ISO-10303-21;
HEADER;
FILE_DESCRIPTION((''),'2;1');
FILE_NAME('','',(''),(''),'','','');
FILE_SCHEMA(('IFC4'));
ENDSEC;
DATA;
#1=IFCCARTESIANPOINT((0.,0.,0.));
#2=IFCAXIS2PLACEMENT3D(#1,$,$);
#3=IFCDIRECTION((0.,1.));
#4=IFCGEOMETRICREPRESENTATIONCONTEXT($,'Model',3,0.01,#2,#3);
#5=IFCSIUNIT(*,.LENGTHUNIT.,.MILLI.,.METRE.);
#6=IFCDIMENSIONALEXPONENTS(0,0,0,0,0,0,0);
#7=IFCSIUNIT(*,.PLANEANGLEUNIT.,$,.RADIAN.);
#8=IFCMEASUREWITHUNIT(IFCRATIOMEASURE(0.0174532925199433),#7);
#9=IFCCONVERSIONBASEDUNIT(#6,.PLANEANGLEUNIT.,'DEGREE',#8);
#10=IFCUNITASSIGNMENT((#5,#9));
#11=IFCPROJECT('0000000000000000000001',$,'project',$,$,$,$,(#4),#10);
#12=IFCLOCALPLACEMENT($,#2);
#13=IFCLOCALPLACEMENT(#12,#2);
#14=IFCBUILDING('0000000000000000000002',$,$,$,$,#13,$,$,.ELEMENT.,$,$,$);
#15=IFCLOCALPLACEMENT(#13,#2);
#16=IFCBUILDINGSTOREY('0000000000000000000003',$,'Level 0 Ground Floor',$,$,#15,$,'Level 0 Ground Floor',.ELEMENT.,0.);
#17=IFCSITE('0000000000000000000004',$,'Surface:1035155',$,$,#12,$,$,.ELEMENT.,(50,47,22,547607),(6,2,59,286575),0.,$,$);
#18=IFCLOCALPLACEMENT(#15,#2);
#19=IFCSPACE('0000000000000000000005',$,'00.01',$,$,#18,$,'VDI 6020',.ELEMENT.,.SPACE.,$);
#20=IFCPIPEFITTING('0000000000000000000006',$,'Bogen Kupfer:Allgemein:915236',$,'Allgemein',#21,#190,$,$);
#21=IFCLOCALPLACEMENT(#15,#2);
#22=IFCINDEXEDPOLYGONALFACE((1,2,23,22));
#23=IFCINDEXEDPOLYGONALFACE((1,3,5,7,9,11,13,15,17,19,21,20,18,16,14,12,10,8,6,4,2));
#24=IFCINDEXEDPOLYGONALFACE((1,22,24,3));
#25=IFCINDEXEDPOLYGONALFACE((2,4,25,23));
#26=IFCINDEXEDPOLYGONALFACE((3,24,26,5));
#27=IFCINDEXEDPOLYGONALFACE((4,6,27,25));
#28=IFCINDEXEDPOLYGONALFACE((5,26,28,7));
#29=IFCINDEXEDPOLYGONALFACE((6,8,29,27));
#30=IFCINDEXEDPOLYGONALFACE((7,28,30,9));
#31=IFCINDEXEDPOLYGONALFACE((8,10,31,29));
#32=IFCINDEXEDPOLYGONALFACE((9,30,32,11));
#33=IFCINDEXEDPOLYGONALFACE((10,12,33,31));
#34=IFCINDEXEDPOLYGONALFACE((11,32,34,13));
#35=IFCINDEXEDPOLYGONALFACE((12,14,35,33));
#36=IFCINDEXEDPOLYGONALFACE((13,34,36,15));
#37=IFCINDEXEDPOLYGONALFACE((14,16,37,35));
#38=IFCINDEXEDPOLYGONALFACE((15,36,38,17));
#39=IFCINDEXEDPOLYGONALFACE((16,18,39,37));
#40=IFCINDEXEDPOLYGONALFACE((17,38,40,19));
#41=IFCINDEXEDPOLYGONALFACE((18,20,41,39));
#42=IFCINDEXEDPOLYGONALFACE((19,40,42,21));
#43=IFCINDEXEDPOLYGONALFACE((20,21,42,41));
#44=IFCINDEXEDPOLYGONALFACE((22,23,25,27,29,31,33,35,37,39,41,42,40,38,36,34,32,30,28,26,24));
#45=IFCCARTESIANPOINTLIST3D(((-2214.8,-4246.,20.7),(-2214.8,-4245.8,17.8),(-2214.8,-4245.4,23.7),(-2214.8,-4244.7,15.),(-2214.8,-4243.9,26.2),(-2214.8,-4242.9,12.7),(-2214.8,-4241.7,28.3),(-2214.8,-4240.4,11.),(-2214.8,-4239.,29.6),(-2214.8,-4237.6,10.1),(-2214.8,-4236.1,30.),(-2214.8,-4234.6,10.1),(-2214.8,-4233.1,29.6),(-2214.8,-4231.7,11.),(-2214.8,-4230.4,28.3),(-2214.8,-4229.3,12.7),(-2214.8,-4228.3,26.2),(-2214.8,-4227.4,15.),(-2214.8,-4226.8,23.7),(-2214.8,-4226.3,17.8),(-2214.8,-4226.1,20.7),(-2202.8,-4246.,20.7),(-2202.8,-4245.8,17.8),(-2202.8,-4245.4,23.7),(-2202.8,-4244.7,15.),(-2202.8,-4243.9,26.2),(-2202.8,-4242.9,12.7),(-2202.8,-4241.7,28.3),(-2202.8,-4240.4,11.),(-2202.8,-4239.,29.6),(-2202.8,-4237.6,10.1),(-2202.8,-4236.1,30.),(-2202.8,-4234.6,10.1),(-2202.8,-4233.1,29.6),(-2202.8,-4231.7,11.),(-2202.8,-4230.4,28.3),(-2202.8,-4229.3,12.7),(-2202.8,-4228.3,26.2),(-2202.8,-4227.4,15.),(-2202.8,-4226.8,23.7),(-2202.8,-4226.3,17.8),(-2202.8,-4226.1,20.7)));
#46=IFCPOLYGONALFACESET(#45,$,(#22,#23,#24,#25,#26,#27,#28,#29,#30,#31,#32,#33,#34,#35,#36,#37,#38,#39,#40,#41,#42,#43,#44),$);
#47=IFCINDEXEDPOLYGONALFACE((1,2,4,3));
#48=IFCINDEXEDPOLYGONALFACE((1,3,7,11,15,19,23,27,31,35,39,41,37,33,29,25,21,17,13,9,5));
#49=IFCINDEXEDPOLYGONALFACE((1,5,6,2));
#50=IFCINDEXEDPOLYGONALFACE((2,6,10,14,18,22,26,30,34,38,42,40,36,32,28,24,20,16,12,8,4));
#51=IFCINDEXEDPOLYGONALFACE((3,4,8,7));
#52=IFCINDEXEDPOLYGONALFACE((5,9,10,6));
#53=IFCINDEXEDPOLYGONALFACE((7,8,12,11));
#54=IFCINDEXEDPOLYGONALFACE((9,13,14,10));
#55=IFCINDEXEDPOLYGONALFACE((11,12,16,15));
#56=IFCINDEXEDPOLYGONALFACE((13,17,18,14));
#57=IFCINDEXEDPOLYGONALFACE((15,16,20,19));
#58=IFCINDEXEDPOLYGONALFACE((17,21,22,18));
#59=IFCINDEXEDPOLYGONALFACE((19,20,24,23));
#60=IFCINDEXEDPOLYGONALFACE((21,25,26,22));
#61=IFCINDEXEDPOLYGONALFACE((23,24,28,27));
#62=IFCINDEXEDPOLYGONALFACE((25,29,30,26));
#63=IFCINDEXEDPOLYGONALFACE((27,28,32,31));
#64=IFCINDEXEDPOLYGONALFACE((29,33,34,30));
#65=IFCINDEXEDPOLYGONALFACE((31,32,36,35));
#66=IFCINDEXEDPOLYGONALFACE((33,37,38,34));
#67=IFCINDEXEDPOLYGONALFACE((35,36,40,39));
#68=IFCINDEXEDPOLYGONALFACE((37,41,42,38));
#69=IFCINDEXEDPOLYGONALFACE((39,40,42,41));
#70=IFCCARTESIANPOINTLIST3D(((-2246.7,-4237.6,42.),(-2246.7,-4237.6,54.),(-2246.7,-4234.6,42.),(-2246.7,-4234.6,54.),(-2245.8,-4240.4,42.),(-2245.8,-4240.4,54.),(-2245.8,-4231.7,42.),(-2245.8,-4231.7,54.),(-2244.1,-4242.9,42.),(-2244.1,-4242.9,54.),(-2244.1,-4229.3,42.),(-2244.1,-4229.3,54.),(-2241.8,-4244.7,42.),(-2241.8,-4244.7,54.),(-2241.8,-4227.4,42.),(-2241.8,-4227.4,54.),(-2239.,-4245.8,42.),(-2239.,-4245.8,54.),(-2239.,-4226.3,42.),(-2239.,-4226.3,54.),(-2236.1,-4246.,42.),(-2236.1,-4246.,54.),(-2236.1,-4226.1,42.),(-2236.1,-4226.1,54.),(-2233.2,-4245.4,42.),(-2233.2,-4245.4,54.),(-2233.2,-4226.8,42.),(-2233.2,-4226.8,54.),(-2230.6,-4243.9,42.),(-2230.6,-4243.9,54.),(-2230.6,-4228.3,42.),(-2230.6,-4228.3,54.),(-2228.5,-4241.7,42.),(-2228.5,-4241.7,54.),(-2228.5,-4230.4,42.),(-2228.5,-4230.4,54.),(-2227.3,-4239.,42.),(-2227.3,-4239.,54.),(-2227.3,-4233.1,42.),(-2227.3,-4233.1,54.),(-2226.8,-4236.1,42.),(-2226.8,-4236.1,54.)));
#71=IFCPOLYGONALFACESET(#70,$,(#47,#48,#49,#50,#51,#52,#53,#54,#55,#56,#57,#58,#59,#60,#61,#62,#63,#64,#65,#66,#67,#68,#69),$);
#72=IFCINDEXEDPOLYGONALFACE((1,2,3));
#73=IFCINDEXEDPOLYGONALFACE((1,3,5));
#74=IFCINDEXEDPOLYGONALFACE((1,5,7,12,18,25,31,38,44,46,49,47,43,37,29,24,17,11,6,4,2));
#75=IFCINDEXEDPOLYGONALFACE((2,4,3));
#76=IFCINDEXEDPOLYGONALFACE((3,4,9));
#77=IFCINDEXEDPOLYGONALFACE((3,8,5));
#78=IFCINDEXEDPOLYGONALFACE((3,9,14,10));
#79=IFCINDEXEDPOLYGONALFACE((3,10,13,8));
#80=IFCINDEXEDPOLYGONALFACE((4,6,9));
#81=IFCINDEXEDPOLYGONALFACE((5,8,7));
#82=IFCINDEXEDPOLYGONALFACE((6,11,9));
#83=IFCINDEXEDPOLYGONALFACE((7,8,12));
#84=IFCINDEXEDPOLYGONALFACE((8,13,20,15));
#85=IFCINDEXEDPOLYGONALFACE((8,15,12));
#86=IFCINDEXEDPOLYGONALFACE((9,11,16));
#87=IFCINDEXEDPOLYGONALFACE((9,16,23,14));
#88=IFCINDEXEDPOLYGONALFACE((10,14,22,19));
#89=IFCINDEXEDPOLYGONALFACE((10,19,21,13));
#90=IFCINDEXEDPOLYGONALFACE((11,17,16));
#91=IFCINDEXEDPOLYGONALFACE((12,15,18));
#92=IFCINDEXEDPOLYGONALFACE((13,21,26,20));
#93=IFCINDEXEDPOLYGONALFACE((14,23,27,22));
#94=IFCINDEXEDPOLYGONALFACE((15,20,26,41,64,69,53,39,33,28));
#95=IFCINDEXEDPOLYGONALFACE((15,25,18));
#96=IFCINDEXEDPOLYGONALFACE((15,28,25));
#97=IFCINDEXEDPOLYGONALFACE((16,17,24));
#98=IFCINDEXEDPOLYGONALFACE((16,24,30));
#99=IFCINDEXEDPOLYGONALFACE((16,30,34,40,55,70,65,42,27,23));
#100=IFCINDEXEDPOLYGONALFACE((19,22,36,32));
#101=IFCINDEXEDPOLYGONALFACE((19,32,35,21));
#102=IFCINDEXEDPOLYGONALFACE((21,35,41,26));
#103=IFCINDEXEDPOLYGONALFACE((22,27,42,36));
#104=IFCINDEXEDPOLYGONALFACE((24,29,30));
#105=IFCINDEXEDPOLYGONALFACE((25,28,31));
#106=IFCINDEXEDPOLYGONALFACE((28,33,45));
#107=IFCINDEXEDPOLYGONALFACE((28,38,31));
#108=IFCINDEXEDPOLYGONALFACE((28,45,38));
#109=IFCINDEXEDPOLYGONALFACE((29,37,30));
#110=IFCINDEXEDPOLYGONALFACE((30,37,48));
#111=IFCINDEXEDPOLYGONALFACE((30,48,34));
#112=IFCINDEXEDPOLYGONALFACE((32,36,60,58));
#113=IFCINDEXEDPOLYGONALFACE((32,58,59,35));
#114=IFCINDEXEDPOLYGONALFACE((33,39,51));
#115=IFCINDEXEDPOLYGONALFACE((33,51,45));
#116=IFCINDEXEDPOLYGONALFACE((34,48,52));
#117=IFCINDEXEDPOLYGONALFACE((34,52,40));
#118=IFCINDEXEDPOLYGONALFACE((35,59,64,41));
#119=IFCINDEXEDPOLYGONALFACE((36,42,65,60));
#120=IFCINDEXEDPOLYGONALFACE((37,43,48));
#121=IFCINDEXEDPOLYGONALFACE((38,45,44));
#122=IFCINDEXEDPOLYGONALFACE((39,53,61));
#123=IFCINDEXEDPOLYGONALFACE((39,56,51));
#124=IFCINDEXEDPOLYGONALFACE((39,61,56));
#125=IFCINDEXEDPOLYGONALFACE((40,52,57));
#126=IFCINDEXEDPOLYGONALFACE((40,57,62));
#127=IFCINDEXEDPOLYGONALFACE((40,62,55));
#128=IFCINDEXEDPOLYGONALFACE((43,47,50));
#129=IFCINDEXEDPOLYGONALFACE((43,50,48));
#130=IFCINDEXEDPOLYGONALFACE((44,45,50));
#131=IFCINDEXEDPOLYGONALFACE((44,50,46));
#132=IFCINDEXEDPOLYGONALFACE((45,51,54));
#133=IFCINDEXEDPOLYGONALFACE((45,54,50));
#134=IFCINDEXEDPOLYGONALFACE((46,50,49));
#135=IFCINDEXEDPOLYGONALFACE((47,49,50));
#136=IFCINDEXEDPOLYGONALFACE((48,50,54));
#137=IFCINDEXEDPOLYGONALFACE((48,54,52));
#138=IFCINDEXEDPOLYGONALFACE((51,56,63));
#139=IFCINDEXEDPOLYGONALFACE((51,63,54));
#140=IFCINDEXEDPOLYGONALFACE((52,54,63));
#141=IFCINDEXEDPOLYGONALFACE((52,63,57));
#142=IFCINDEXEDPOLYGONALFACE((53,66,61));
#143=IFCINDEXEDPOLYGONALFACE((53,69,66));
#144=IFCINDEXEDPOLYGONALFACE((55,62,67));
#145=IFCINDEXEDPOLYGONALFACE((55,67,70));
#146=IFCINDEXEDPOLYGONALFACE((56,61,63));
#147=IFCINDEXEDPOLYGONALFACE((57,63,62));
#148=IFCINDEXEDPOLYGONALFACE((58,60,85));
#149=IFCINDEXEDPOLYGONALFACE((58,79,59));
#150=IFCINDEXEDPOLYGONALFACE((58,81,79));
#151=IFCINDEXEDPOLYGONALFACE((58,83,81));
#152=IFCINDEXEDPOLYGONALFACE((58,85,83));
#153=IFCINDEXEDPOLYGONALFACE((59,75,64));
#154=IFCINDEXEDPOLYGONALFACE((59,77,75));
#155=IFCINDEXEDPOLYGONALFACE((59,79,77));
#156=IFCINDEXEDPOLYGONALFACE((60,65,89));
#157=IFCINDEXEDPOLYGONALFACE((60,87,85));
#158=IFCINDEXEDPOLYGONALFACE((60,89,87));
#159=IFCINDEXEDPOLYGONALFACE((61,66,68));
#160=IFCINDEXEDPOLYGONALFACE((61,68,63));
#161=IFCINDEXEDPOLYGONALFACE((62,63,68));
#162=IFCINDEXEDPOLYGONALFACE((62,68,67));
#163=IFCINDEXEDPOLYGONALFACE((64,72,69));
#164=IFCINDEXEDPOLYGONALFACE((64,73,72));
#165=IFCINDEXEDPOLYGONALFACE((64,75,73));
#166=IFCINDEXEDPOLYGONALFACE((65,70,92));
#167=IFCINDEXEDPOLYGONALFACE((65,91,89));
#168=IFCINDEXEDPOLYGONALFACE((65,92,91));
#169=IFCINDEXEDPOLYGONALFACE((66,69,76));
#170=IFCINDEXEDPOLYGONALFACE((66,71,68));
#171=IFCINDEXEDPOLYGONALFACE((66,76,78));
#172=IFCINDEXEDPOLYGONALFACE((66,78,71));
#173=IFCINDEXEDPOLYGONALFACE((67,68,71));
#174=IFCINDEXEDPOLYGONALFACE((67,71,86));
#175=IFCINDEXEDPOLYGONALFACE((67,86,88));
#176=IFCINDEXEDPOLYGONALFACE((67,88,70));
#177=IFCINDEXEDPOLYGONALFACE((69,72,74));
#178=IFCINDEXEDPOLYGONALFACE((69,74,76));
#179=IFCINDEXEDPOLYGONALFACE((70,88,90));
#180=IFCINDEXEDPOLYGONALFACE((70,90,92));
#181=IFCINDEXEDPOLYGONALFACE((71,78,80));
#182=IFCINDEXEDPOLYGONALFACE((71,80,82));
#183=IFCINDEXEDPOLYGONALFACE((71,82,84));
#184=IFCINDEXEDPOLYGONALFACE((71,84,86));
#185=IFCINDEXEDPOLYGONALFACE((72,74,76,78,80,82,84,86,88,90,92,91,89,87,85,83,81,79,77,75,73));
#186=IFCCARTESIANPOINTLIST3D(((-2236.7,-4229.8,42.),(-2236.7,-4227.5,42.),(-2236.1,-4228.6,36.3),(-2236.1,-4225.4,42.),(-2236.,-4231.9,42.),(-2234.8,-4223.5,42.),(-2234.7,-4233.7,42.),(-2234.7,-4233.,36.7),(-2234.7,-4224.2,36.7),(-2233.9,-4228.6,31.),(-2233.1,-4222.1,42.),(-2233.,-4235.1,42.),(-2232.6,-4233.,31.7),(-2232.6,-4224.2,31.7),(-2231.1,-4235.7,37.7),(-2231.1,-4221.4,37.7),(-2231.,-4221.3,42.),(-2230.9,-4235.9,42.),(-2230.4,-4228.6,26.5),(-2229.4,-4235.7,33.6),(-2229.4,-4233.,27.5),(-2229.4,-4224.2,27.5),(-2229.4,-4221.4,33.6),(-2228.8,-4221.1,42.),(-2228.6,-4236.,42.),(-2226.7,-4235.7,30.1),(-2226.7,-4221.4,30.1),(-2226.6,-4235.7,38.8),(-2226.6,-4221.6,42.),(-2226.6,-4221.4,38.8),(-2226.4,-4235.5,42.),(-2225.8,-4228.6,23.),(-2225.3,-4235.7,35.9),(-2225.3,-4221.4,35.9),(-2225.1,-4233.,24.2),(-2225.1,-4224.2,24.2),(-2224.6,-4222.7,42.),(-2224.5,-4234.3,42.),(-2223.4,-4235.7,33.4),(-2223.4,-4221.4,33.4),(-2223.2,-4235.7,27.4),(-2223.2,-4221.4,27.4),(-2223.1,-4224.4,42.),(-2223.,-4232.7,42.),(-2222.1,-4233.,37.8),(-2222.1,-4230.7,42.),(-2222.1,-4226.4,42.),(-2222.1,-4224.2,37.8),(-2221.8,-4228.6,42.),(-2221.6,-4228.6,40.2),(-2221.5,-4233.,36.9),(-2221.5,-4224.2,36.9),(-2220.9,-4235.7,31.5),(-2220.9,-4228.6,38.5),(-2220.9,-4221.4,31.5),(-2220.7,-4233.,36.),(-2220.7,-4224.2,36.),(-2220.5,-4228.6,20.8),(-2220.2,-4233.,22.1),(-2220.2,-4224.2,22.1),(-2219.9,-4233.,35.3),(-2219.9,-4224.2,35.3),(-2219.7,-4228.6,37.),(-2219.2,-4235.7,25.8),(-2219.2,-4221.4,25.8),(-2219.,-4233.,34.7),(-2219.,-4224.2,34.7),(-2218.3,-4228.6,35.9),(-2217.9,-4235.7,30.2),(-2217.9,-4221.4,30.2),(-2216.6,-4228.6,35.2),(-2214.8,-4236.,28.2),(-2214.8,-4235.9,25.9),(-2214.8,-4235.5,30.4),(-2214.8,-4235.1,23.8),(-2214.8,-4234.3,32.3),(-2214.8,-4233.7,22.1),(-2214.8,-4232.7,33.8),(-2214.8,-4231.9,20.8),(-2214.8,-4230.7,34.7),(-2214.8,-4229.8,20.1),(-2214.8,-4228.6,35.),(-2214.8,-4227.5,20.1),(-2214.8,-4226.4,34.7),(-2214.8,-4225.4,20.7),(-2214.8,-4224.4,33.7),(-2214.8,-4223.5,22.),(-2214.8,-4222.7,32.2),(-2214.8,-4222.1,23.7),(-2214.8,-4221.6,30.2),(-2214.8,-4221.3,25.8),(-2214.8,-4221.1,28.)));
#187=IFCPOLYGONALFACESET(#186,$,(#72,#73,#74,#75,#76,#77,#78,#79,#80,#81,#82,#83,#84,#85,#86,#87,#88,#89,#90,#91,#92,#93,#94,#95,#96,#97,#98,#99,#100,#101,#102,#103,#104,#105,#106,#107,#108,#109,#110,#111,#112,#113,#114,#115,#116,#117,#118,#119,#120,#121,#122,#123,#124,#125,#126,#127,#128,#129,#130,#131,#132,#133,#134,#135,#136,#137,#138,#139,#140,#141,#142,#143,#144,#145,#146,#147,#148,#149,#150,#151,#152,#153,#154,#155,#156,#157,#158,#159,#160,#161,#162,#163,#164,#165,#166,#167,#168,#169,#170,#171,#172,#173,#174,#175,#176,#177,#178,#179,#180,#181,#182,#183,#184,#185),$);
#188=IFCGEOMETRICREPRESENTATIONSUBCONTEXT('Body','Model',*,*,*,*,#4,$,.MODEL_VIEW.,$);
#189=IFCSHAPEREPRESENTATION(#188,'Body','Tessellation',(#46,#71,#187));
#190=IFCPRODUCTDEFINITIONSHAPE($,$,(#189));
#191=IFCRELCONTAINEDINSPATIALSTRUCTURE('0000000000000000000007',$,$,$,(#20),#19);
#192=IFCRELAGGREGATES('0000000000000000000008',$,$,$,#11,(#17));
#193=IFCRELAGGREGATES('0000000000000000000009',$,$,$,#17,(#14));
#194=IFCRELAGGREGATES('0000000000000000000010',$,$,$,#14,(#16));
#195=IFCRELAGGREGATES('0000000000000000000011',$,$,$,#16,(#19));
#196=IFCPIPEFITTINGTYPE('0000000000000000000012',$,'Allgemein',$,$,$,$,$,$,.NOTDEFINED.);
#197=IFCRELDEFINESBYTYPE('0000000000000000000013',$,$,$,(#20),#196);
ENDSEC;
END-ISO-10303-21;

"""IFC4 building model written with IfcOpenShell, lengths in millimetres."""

from ifc_helpers import new_model, entity, si_unit, converted_unit, direction, frame, frame_2d, origin, place, context, subcontext, project, spatial, circle, extrude, source, transform, mapped, type_object, type_shapes, element, save


model = new_model("IFC4")

# Units and contexts
model_context = context("Model", 3, precision=0.01, world=origin(), true_north=direction((0.0, 1.0)))
body_context = subcontext(model_context, "Body", "Model", "MODEL_VIEW")
ifc_project = project(units=[si_unit("LENGTHUNIT", "METRE", prefix="MILLI"), converted_unit("PLANEANGLEUNIT", "DEGREE", entity("IfcRatioMeasure", 0.0174532925199433), si_unit("PLANEANGLEUNIT", "RADIAN"), dimensions=[0, 0, 0, 0, 0, 0, 0])], contexts=[model_context])

# Site, building, storey
site_placement = place(None, origin())
site = spatial("IfcSite", under=ifc_project, at=site_placement, Name="Surface:1035155", CompositionType="ELEMENT", RefLatitude=(50, 47, 22, 547607), RefLongitude=(6, 2, 59, 286575), RefElevation=0.0)
building_placement = place(site_placement, origin())
building = spatial("IfcBuilding", under=site, at=building_placement, CompositionType="ELEMENT")
storey_placement = place(building_placement, origin())
storey = spatial("IfcBuildingStorey", under=building, at=storey_placement, Name="Level 0 Ground Floor", LongName="Level 0 Ground Floor", CompositionType="ELEMENT", Elevation=0.0)

# Shared definitions
pipe_fitting_type = type_object("IfcPipeFittingType", Name="Allgemein", PredefinedType="NOTDEFINED")
ifc_direction = entity("IfcDirection", [0.0, 0.0, -1.0])
trimmed_curve = entity("IfcTrimmedCurve", entity("IfcCircle", entity("IfcAxis2Placement2D", entity("IfcCartesianPoint", [-14.5, 0.0]), entity("IfcDirection", [0.0, 1.0])), 14.5), [entity("IfcParameterValue", 270.0)], [entity("IfcParameterValue", 0.0)], True, "PARAMETER")
shared_shape_1 = source(origin(), body_context, "Body", "SolidModel", [
    extrude(circle(Radius=10.0, at=frame_2d((0.0, 0.0), x_axis=(1.0, 0.0))), frame((0.0, 22.0, 0.0), z_axis=(0.0, 1.0, 0.0), x_axis=(-1.0, 0.0, 0.0)), (0.0, 0.0, 1.0), 12.0),
    extrude(circle(Radius=10.0, at=frame_2d((0.0, 0.0), x_axis=(1.0, 0.0))), frame((-34.0, 0.0, 0.0), z_axis=(1.0, 0.0, 0.0), x_axis=(0.0, 1.0, 0.0)), (0.0, 0.0, 1.0), 12.0),
    entity("IfcSurfaceCurveSweptAreaSolid", entity("IfcCircleProfileDef", "AREA", None, entity("IfcAxis2Placement2D", entity("IfcCartesianPoint", [0.0, 7.5]), entity("IfcDirection", [1.0, 0.0])), 7.5), entity("IfcAxis2Placement3D", entity("IfcCartesianPoint", [-7.5, 22.0, 0.0]), ifc_direction, entity("IfcDirection", [1.0, 0.0, 0.0])), trimmed_curve, 0.0, 90.0, entity("IfcSurfaceOfLinearExtrusion", entity("IfcArbitraryOpenProfileDef", "CURVE", None, trimmed_curve), entity("IfcAxis2Placement3D", entity("IfcCartesianPoint", [0.0, 0.0, -304.8])), ifc_direction, 1.0)),
])
type_shapes(pipe_fitting_type, [shared_shape_1])

# Shared definitions
space_placement = place(storey_placement, origin())
space = spatial("IfcSpace", under=storey, at=space_placement, Name="00.01", LongName="VDI 6020", CompositionType="ELEMENT", PredefinedType="SPACE")

# Pipe fitting
pipe_fitting_placement = place(space_placement, frame((-2236.8, -4236.1, 20.0), z_axis=(0.0, -1.0, 0.0), x_axis=(0.0, 0.0, -1.0)))
element("IfcPipeFitting", 1, at=pipe_fitting_placement, inside=space, type_object=pipe_fitting_type, Name="Bogen Kupfer:Allgemein:915236", ObjectType="Allgemein", context=body_context, shape_type="MappedRepresentation", body=[
    mapped(shared_shape_1, transform((0.0, 0.0, 0.0), scale=1.0)),
])

save(model, "model.ifc")
